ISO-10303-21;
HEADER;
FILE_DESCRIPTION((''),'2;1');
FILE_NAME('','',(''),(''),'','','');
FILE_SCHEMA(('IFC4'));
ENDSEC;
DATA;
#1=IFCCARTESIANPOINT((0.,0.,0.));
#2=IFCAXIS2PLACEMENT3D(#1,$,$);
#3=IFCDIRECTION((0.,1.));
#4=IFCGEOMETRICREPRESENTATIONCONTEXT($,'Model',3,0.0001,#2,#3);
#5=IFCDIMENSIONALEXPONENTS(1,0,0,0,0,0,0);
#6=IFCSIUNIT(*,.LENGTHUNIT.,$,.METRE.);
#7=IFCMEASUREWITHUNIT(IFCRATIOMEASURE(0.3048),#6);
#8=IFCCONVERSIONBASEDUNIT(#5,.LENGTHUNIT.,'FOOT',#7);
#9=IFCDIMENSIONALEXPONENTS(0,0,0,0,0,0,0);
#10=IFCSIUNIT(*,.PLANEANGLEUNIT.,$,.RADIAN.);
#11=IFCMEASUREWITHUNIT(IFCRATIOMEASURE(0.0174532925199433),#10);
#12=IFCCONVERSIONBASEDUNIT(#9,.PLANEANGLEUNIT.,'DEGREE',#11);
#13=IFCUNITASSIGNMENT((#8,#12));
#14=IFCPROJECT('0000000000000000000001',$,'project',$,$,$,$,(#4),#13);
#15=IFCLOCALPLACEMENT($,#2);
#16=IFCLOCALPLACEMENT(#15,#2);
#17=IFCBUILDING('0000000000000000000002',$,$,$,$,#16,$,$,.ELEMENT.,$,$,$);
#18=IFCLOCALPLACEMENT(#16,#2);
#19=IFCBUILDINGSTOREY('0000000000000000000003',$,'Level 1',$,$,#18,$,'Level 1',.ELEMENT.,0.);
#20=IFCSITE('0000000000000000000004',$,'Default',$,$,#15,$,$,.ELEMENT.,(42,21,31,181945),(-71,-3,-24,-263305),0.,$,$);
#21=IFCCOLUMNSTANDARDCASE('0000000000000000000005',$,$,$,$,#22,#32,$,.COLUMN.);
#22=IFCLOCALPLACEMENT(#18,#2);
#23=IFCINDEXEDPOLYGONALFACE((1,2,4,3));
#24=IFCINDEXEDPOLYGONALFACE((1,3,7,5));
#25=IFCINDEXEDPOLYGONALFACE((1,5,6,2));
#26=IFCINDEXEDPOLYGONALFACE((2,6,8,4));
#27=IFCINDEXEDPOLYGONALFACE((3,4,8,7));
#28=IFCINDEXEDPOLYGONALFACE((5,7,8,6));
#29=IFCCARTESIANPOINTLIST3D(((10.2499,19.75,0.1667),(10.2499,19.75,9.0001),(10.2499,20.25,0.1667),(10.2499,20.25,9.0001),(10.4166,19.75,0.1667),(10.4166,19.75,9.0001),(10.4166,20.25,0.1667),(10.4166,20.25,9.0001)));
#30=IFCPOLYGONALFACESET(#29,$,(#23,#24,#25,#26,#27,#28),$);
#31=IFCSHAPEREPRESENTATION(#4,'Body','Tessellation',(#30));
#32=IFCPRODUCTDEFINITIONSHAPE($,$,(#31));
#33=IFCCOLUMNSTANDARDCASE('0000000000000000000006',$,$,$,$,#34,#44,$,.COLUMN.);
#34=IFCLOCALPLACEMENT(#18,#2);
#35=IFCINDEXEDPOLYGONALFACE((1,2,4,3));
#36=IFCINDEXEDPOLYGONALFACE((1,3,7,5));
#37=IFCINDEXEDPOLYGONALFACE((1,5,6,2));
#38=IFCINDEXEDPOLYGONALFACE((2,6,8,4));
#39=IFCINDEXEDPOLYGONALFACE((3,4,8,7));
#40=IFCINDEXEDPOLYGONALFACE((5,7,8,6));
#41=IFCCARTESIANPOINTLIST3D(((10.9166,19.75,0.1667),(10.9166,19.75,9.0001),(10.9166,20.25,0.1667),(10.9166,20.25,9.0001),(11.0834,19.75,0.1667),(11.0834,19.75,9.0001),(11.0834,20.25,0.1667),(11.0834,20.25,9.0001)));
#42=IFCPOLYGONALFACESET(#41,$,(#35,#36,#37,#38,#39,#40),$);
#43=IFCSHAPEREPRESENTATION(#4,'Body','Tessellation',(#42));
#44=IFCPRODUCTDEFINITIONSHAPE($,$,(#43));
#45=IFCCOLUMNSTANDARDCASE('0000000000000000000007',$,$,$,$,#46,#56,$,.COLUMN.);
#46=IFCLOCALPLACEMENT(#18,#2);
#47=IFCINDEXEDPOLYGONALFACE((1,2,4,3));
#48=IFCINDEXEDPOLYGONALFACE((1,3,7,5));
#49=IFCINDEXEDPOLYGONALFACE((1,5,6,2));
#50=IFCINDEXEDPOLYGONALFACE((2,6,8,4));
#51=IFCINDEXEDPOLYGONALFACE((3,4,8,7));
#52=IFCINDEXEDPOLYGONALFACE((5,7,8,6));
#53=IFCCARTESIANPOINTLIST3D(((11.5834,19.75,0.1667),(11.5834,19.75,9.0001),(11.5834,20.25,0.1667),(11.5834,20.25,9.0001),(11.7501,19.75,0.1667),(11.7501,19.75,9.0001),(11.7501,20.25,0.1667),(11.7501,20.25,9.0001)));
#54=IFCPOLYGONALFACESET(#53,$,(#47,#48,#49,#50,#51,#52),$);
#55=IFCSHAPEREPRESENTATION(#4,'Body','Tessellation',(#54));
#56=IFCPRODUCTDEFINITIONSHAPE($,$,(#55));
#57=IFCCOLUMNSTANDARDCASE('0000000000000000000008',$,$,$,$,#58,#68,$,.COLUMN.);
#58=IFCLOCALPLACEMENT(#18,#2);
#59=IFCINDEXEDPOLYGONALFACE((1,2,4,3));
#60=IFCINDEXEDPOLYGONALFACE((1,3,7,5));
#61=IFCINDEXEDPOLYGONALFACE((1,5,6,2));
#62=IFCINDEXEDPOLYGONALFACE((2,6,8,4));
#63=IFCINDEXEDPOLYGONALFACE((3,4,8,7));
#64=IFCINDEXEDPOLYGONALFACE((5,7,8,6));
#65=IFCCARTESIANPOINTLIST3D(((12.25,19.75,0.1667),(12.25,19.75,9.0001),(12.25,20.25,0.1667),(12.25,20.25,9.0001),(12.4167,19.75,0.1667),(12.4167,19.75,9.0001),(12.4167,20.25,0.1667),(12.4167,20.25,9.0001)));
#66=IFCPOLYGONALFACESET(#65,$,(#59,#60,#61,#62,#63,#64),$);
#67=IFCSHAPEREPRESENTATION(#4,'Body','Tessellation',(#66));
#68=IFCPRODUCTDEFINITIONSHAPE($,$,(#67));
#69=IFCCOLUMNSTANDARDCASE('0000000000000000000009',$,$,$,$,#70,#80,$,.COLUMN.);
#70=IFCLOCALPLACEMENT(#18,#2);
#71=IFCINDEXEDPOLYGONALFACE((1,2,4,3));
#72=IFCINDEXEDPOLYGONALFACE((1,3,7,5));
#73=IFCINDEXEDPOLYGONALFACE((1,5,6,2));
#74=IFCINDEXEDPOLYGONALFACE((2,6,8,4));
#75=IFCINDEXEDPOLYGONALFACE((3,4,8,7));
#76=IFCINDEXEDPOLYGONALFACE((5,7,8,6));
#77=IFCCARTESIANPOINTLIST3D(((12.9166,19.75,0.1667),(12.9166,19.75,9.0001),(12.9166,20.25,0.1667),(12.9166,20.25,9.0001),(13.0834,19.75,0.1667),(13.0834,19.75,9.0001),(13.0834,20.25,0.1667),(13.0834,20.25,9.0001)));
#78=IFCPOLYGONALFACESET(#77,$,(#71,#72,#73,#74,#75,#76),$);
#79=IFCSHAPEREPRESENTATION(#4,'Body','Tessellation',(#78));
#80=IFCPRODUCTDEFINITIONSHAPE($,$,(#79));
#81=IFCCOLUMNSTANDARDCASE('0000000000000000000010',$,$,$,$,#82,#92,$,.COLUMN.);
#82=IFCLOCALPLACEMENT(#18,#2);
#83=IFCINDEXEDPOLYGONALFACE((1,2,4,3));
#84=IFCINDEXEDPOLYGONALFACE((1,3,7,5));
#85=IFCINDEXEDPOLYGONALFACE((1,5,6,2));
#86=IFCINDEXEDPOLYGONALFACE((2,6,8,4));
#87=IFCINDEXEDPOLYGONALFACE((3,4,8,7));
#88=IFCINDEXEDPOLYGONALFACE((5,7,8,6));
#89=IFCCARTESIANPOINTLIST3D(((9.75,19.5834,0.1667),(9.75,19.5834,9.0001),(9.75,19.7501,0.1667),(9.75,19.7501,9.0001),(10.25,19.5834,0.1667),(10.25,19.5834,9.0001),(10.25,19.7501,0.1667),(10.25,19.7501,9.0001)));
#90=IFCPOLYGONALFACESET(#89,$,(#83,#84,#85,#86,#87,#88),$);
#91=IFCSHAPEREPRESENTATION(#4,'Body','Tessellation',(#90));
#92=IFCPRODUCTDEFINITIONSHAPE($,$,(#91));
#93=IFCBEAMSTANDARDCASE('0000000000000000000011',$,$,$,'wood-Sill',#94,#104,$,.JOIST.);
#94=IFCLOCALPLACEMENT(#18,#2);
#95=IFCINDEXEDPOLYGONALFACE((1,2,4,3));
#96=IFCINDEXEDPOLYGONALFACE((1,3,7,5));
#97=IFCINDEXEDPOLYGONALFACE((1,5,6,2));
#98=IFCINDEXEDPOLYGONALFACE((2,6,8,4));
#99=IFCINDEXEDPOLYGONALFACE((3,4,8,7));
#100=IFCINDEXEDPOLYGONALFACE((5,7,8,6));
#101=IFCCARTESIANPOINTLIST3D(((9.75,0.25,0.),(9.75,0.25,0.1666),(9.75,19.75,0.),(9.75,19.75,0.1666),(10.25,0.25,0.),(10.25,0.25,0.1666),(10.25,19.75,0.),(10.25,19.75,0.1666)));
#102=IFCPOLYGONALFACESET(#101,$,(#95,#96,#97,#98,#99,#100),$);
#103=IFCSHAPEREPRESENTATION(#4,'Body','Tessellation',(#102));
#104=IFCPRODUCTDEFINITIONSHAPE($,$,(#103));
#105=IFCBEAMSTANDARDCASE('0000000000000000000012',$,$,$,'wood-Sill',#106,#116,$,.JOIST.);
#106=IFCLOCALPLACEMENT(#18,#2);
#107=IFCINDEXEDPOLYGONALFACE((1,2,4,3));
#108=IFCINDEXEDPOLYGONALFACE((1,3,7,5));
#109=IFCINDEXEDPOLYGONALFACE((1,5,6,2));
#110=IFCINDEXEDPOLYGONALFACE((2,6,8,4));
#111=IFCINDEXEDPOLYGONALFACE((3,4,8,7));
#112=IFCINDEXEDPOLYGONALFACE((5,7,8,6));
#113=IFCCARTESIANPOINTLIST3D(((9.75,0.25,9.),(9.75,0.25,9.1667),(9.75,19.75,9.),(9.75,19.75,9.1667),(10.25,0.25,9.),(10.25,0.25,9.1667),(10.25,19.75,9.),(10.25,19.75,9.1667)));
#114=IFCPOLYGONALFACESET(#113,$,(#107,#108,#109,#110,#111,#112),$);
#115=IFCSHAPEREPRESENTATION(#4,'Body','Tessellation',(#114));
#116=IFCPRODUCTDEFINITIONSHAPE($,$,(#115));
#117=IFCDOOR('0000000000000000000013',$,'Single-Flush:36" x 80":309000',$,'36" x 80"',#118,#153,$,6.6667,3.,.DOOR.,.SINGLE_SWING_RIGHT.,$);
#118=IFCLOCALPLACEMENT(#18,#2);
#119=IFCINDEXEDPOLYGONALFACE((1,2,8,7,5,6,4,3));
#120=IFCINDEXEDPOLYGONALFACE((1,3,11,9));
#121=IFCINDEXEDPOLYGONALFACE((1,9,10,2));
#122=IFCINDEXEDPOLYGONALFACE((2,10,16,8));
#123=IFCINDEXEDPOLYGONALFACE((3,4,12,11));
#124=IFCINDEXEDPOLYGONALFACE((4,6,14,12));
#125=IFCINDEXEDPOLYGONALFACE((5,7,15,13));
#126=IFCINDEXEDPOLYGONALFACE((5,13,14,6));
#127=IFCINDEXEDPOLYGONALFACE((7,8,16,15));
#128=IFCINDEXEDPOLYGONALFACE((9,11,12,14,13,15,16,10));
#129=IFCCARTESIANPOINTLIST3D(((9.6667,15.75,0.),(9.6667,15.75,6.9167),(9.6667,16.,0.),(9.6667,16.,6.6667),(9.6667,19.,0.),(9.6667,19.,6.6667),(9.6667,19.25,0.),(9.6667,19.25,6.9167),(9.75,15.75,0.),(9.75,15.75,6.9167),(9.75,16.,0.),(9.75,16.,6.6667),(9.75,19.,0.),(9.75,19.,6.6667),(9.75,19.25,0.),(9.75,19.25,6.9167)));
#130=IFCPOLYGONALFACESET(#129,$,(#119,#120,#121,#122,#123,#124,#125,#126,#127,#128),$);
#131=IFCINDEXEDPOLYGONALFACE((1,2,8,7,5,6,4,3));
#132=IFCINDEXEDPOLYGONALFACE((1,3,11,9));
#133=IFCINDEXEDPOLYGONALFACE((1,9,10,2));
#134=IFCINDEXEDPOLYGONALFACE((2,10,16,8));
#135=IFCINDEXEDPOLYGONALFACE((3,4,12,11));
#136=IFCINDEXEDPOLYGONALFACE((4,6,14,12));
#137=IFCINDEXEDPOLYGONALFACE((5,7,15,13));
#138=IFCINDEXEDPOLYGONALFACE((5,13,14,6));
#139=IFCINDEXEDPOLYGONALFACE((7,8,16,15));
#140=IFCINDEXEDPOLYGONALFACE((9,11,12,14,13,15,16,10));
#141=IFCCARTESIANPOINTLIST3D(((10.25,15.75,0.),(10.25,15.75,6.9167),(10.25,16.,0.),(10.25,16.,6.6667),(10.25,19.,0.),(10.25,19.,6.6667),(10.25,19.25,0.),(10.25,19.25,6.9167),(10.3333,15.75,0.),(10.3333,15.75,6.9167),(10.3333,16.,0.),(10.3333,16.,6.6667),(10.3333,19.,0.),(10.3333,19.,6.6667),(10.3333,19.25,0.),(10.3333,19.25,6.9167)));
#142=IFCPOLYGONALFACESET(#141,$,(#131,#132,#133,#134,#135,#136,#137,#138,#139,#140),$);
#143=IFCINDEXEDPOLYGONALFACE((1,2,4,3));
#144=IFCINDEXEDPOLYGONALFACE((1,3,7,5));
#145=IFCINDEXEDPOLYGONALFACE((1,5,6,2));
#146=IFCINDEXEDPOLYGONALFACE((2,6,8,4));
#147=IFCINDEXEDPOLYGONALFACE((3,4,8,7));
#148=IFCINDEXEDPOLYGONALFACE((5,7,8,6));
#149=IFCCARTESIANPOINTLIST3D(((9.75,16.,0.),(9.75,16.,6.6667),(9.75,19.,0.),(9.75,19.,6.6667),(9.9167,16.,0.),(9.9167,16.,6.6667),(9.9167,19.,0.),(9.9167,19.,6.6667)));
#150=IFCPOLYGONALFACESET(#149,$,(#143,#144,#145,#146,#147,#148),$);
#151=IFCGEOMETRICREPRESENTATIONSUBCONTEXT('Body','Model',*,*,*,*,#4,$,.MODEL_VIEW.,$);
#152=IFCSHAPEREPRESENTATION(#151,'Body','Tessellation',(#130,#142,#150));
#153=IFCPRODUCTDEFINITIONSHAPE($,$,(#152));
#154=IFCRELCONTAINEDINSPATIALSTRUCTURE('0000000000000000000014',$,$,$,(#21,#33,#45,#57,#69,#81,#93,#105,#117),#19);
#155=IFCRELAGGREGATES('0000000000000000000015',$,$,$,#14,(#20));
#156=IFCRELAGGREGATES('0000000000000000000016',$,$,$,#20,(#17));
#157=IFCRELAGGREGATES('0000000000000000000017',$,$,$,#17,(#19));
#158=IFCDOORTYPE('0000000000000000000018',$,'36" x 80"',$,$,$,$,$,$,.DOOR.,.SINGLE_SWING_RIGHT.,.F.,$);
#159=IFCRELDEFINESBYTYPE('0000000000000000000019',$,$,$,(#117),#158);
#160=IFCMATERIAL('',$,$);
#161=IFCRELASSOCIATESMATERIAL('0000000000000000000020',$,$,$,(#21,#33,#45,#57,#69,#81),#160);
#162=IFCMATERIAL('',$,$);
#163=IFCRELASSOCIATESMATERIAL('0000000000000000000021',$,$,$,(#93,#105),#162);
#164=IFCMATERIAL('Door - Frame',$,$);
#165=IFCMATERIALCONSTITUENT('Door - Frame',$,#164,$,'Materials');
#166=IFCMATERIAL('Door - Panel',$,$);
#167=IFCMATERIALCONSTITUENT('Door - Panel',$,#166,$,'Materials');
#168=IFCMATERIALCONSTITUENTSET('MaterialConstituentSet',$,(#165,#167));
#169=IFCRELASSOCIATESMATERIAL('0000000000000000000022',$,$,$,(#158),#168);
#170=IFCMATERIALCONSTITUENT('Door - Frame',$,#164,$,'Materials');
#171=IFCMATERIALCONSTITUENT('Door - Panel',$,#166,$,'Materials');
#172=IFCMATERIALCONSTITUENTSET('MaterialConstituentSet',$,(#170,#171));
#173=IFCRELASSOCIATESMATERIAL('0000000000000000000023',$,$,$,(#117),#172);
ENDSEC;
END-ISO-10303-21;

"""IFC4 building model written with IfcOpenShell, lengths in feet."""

from ifc_helpers import new_model, entity, si_unit, converted_unit, direction, frame, origin, origin_with_axes, origin_2d_with_axis, place, context, subcontext, project, spatial, polyline, rectangle, outline, extrude, source, transform, mapped, material, constituent, constituent_set, type_object, type_shapes, element, save


model = new_model("IFC4")

# Units and contexts
model_context = context("Model", 3, precision=0.0001, world=origin(), true_north=direction((0.0, 1.0)))
body_context = subcontext(model_context, "Body", "Model", "MODEL_VIEW")
ifc_project = project(units=[converted_unit("LENGTHUNIT", "FOOT", entity("IfcRatioMeasure", 0.3048), si_unit("LENGTHUNIT", "METRE"), dimensions=[1, 0, 0, 0, 0, 0, 0]), converted_unit("PLANEANGLEUNIT", "DEGREE", entity("IfcRatioMeasure", 0.0174532925199433), si_unit("PLANEANGLEUNIT", "RADIAN"), dimensions=[0, 0, 0, 0, 0, 0, 0])], contexts=[model_context])

# Site, building, storey
site_placement = place(None, origin())
site = spatial("IfcSite", under=ifc_project, at=site_placement, Name="Default", CompositionType="ELEMENT", RefLatitude=(42, 21, 31, 181945), RefLongitude=(-71, -3, -24, -263305), RefElevation=0.0)
building_placement = place(site_placement, origin())
building = spatial("IfcBuilding", under=site, at=building_placement, CompositionType="ELEMENT")
storey_placement = place(building_placement, origin())
storey = spatial("IfcBuildingStorey", under=building, at=storey_placement, Name="Level 1", LongName="Level 1", CompositionType="ELEMENT", Elevation=0.0)

# Columns
ifc_material_1 = material(Name="")
placement_1 = place(storey_placement, frame((0.25, 20.0, 0.0)))
for number, where, z_axis, x_axis in (
    (1, (10.0833, 0.0, 0.1667), (0.0, 0.0, 1.0), (1.0, 0.0, 0.0)),
    (2, (10.75, 0.0, 0.1667), (0.0, 0.0, 1.0), (1.0, 0.0, 0.0)),
    (3, (11.4167, 0.0, 0.1667), (0.0, 0.0, 1.0), (1.0, 0.0, 0.0)),
    (4, (12.0834, 0.0, 0.1667), (0.0, 0.0, 1.0), (1.0, 0.0, 0.0)),
    (5, (12.75, 0.0, 0.1667), (0.0, 0.0, 1.0), (1.0, 0.0, 0.0)),
):
    element("IfcColumnStandardCase", number, at=place(placement_1, frame(where, z_axis=z_axis, x_axis=x_axis)), inside=storey, material=ifc_material_1, PredefinedType="COLUMN", context=model_context, shape_type="SweptSolid", body=[
        extrude(rectangle(XDim=0.1667, YDim=0.5), origin(), (0.0, 0.0, 1.0), 8.8334),
    ])
placement_2 = place(storey_placement, frame((10.0, 19.75, 0.0), z_axis=(0.0, 0.0, 1.0), x_axis=(0.0, -1.0, 0.0)))
for number, where, z_axis, x_axis in (
    (6, (0.0833, 0.0, 0.1667), (0.0, 0.0, 1.0), (1.0, 0.0, 0.0)),
):
    element("IfcColumnStandardCase", number, at=place(placement_2, frame(where, z_axis=z_axis, x_axis=x_axis)), inside=storey, material=ifc_material_1, PredefinedType="COLUMN", context=model_context, shape_type="SweptSolid", body=[
        extrude(rectangle(XDim=0.1667, YDim=0.5), origin(), (0.0, 0.0, 1.0), 8.8334),
    ])

# Beams
ifc_material_2 = material(Name="")
for number, where, z_axis, x_axis in (
    (7, (0.0, 0.0, 0.0833), (1.0, 0.0, 0.0), (0.0, 0.0, 1.0)),
    (8, (0.0, 0.0, 9.0834), (1.0, 0.0, 0.0), (0.0, 0.0, 1.0)),
):
    element("IfcBeamStandardCase", number, at=place(placement_2, frame(where, z_axis=z_axis, x_axis=x_axis)), inside=storey, material=ifc_material_2, ObjectType="wood-Sill", PredefinedType="JOIST", context=model_context, shape_type="SweptSolid", body=[
        extrude(rectangle(XDim=0.1667, YDim=0.5), origin_with_axes(), (0.0, 0.0, 1.0), 19.5),
    ])

# Door
ifc_material_3 = material(Name="Door - Frame")
ifc_constituent_1 = constituent(ifc_material_3, Name="Door - Frame", Category="Materials")
ifc_material_4 = material(Name="Door - Panel")
ifc_constituent_2 = constituent(ifc_material_4, Name="Door - Panel", Category="Materials")
ifc_constituent_set_1 = constituent_set(constituents=[ifc_constituent_1, ifc_constituent_2], Name="MaterialConstituentSet")
ifc_constituent_3 = constituent(ifc_material_3, Name="Door - Frame", Category="Materials")
ifc_constituent_4 = constituent(ifc_material_4, Name="Door - Panel", Category="Materials")
ifc_constituent_set_2 = constituent_set(constituents=[ifc_constituent_3, ifc_constituent_4], Name="MaterialConstituentSet")
door_type = type_object("IfcDoorType", Name="36\" x 80\"", OperationType="SINGLE_SWING_RIGHT", ParameterTakesPrecedence=False, PredefinedType="DOOR", material=ifc_constituent_set_2)
shared_shape = source(origin(), body_context, "Body", "SweptSolid", [
    extrude(outline(polyline([(-1.75, -3.5208), (1.75, -3.5208), (1.75, 3.3958), (1.5, 3.3958), (1.5, -3.2708), (-1.5, -3.2708), (-1.5, 3.3958), (-1.75, 3.3958), (-1.75, -3.5208)])), frame((1.5, 0.5, 3.3958), z_axis=(0.0, 1.0, 0.0), x_axis=(1.0, 0.0, 0.0)), (0.0, 0.0, 1.0), 0.0833),
    extrude(outline(polyline([(-3.5208, -1.75), (3.3958, -1.75), (3.3958, -1.5), (-3.2708, -1.5), (-3.2708, 1.5), (3.3958, 1.5), (3.3958, 1.75), (-3.5208, 1.75), (-3.5208, -1.75)])), frame((1.5, -0.0833, 3.3958), z_axis=(0.0, 1.0, 0.0), x_axis=(0.0, 0.0, -1.0)), (0.0, 0.0, 1.0), 0.0833),
    extrude(rectangle(XDim=0.1667, YDim=3.0, at=origin_2d_with_axis()), frame((1.5, 0.4167, 0.0), z_axis=(0.0, 0.0, 1.0), x_axis=(0.0, 1.0, 0.0)), (0.0, 0.0, 1.0), 6.6667),
])
type_shapes(door_type, [shared_shape])
placement_3 = place(placement_2, frame((3.75, 0.25, 0.0)))
door_placement = place(placement_3, frame((0.0, 0.0, 0.0), z_axis=(0.0, 0.0, 1.0), x_axis=(-1.0, 0.0, 0.0)))
element("IfcDoor", 9, at=door_placement, inside=storey, type_object=door_type, material=ifc_constituent_set_1, Name="Single-Flush:36\" x 80\":309000", ObjectType="36\" x 80\"", OperationType="SINGLE_SWING_RIGHT", OverallHeight=6.6667, OverallWidth=3.0, PredefinedType="DOOR", context=body_context, shape_type="MappedRepresentation", body=[
    mapped(shared_shape, transform((0.0, 0.0, 0.0), scale=1.0)),
])

save(model, "model.ifc")
